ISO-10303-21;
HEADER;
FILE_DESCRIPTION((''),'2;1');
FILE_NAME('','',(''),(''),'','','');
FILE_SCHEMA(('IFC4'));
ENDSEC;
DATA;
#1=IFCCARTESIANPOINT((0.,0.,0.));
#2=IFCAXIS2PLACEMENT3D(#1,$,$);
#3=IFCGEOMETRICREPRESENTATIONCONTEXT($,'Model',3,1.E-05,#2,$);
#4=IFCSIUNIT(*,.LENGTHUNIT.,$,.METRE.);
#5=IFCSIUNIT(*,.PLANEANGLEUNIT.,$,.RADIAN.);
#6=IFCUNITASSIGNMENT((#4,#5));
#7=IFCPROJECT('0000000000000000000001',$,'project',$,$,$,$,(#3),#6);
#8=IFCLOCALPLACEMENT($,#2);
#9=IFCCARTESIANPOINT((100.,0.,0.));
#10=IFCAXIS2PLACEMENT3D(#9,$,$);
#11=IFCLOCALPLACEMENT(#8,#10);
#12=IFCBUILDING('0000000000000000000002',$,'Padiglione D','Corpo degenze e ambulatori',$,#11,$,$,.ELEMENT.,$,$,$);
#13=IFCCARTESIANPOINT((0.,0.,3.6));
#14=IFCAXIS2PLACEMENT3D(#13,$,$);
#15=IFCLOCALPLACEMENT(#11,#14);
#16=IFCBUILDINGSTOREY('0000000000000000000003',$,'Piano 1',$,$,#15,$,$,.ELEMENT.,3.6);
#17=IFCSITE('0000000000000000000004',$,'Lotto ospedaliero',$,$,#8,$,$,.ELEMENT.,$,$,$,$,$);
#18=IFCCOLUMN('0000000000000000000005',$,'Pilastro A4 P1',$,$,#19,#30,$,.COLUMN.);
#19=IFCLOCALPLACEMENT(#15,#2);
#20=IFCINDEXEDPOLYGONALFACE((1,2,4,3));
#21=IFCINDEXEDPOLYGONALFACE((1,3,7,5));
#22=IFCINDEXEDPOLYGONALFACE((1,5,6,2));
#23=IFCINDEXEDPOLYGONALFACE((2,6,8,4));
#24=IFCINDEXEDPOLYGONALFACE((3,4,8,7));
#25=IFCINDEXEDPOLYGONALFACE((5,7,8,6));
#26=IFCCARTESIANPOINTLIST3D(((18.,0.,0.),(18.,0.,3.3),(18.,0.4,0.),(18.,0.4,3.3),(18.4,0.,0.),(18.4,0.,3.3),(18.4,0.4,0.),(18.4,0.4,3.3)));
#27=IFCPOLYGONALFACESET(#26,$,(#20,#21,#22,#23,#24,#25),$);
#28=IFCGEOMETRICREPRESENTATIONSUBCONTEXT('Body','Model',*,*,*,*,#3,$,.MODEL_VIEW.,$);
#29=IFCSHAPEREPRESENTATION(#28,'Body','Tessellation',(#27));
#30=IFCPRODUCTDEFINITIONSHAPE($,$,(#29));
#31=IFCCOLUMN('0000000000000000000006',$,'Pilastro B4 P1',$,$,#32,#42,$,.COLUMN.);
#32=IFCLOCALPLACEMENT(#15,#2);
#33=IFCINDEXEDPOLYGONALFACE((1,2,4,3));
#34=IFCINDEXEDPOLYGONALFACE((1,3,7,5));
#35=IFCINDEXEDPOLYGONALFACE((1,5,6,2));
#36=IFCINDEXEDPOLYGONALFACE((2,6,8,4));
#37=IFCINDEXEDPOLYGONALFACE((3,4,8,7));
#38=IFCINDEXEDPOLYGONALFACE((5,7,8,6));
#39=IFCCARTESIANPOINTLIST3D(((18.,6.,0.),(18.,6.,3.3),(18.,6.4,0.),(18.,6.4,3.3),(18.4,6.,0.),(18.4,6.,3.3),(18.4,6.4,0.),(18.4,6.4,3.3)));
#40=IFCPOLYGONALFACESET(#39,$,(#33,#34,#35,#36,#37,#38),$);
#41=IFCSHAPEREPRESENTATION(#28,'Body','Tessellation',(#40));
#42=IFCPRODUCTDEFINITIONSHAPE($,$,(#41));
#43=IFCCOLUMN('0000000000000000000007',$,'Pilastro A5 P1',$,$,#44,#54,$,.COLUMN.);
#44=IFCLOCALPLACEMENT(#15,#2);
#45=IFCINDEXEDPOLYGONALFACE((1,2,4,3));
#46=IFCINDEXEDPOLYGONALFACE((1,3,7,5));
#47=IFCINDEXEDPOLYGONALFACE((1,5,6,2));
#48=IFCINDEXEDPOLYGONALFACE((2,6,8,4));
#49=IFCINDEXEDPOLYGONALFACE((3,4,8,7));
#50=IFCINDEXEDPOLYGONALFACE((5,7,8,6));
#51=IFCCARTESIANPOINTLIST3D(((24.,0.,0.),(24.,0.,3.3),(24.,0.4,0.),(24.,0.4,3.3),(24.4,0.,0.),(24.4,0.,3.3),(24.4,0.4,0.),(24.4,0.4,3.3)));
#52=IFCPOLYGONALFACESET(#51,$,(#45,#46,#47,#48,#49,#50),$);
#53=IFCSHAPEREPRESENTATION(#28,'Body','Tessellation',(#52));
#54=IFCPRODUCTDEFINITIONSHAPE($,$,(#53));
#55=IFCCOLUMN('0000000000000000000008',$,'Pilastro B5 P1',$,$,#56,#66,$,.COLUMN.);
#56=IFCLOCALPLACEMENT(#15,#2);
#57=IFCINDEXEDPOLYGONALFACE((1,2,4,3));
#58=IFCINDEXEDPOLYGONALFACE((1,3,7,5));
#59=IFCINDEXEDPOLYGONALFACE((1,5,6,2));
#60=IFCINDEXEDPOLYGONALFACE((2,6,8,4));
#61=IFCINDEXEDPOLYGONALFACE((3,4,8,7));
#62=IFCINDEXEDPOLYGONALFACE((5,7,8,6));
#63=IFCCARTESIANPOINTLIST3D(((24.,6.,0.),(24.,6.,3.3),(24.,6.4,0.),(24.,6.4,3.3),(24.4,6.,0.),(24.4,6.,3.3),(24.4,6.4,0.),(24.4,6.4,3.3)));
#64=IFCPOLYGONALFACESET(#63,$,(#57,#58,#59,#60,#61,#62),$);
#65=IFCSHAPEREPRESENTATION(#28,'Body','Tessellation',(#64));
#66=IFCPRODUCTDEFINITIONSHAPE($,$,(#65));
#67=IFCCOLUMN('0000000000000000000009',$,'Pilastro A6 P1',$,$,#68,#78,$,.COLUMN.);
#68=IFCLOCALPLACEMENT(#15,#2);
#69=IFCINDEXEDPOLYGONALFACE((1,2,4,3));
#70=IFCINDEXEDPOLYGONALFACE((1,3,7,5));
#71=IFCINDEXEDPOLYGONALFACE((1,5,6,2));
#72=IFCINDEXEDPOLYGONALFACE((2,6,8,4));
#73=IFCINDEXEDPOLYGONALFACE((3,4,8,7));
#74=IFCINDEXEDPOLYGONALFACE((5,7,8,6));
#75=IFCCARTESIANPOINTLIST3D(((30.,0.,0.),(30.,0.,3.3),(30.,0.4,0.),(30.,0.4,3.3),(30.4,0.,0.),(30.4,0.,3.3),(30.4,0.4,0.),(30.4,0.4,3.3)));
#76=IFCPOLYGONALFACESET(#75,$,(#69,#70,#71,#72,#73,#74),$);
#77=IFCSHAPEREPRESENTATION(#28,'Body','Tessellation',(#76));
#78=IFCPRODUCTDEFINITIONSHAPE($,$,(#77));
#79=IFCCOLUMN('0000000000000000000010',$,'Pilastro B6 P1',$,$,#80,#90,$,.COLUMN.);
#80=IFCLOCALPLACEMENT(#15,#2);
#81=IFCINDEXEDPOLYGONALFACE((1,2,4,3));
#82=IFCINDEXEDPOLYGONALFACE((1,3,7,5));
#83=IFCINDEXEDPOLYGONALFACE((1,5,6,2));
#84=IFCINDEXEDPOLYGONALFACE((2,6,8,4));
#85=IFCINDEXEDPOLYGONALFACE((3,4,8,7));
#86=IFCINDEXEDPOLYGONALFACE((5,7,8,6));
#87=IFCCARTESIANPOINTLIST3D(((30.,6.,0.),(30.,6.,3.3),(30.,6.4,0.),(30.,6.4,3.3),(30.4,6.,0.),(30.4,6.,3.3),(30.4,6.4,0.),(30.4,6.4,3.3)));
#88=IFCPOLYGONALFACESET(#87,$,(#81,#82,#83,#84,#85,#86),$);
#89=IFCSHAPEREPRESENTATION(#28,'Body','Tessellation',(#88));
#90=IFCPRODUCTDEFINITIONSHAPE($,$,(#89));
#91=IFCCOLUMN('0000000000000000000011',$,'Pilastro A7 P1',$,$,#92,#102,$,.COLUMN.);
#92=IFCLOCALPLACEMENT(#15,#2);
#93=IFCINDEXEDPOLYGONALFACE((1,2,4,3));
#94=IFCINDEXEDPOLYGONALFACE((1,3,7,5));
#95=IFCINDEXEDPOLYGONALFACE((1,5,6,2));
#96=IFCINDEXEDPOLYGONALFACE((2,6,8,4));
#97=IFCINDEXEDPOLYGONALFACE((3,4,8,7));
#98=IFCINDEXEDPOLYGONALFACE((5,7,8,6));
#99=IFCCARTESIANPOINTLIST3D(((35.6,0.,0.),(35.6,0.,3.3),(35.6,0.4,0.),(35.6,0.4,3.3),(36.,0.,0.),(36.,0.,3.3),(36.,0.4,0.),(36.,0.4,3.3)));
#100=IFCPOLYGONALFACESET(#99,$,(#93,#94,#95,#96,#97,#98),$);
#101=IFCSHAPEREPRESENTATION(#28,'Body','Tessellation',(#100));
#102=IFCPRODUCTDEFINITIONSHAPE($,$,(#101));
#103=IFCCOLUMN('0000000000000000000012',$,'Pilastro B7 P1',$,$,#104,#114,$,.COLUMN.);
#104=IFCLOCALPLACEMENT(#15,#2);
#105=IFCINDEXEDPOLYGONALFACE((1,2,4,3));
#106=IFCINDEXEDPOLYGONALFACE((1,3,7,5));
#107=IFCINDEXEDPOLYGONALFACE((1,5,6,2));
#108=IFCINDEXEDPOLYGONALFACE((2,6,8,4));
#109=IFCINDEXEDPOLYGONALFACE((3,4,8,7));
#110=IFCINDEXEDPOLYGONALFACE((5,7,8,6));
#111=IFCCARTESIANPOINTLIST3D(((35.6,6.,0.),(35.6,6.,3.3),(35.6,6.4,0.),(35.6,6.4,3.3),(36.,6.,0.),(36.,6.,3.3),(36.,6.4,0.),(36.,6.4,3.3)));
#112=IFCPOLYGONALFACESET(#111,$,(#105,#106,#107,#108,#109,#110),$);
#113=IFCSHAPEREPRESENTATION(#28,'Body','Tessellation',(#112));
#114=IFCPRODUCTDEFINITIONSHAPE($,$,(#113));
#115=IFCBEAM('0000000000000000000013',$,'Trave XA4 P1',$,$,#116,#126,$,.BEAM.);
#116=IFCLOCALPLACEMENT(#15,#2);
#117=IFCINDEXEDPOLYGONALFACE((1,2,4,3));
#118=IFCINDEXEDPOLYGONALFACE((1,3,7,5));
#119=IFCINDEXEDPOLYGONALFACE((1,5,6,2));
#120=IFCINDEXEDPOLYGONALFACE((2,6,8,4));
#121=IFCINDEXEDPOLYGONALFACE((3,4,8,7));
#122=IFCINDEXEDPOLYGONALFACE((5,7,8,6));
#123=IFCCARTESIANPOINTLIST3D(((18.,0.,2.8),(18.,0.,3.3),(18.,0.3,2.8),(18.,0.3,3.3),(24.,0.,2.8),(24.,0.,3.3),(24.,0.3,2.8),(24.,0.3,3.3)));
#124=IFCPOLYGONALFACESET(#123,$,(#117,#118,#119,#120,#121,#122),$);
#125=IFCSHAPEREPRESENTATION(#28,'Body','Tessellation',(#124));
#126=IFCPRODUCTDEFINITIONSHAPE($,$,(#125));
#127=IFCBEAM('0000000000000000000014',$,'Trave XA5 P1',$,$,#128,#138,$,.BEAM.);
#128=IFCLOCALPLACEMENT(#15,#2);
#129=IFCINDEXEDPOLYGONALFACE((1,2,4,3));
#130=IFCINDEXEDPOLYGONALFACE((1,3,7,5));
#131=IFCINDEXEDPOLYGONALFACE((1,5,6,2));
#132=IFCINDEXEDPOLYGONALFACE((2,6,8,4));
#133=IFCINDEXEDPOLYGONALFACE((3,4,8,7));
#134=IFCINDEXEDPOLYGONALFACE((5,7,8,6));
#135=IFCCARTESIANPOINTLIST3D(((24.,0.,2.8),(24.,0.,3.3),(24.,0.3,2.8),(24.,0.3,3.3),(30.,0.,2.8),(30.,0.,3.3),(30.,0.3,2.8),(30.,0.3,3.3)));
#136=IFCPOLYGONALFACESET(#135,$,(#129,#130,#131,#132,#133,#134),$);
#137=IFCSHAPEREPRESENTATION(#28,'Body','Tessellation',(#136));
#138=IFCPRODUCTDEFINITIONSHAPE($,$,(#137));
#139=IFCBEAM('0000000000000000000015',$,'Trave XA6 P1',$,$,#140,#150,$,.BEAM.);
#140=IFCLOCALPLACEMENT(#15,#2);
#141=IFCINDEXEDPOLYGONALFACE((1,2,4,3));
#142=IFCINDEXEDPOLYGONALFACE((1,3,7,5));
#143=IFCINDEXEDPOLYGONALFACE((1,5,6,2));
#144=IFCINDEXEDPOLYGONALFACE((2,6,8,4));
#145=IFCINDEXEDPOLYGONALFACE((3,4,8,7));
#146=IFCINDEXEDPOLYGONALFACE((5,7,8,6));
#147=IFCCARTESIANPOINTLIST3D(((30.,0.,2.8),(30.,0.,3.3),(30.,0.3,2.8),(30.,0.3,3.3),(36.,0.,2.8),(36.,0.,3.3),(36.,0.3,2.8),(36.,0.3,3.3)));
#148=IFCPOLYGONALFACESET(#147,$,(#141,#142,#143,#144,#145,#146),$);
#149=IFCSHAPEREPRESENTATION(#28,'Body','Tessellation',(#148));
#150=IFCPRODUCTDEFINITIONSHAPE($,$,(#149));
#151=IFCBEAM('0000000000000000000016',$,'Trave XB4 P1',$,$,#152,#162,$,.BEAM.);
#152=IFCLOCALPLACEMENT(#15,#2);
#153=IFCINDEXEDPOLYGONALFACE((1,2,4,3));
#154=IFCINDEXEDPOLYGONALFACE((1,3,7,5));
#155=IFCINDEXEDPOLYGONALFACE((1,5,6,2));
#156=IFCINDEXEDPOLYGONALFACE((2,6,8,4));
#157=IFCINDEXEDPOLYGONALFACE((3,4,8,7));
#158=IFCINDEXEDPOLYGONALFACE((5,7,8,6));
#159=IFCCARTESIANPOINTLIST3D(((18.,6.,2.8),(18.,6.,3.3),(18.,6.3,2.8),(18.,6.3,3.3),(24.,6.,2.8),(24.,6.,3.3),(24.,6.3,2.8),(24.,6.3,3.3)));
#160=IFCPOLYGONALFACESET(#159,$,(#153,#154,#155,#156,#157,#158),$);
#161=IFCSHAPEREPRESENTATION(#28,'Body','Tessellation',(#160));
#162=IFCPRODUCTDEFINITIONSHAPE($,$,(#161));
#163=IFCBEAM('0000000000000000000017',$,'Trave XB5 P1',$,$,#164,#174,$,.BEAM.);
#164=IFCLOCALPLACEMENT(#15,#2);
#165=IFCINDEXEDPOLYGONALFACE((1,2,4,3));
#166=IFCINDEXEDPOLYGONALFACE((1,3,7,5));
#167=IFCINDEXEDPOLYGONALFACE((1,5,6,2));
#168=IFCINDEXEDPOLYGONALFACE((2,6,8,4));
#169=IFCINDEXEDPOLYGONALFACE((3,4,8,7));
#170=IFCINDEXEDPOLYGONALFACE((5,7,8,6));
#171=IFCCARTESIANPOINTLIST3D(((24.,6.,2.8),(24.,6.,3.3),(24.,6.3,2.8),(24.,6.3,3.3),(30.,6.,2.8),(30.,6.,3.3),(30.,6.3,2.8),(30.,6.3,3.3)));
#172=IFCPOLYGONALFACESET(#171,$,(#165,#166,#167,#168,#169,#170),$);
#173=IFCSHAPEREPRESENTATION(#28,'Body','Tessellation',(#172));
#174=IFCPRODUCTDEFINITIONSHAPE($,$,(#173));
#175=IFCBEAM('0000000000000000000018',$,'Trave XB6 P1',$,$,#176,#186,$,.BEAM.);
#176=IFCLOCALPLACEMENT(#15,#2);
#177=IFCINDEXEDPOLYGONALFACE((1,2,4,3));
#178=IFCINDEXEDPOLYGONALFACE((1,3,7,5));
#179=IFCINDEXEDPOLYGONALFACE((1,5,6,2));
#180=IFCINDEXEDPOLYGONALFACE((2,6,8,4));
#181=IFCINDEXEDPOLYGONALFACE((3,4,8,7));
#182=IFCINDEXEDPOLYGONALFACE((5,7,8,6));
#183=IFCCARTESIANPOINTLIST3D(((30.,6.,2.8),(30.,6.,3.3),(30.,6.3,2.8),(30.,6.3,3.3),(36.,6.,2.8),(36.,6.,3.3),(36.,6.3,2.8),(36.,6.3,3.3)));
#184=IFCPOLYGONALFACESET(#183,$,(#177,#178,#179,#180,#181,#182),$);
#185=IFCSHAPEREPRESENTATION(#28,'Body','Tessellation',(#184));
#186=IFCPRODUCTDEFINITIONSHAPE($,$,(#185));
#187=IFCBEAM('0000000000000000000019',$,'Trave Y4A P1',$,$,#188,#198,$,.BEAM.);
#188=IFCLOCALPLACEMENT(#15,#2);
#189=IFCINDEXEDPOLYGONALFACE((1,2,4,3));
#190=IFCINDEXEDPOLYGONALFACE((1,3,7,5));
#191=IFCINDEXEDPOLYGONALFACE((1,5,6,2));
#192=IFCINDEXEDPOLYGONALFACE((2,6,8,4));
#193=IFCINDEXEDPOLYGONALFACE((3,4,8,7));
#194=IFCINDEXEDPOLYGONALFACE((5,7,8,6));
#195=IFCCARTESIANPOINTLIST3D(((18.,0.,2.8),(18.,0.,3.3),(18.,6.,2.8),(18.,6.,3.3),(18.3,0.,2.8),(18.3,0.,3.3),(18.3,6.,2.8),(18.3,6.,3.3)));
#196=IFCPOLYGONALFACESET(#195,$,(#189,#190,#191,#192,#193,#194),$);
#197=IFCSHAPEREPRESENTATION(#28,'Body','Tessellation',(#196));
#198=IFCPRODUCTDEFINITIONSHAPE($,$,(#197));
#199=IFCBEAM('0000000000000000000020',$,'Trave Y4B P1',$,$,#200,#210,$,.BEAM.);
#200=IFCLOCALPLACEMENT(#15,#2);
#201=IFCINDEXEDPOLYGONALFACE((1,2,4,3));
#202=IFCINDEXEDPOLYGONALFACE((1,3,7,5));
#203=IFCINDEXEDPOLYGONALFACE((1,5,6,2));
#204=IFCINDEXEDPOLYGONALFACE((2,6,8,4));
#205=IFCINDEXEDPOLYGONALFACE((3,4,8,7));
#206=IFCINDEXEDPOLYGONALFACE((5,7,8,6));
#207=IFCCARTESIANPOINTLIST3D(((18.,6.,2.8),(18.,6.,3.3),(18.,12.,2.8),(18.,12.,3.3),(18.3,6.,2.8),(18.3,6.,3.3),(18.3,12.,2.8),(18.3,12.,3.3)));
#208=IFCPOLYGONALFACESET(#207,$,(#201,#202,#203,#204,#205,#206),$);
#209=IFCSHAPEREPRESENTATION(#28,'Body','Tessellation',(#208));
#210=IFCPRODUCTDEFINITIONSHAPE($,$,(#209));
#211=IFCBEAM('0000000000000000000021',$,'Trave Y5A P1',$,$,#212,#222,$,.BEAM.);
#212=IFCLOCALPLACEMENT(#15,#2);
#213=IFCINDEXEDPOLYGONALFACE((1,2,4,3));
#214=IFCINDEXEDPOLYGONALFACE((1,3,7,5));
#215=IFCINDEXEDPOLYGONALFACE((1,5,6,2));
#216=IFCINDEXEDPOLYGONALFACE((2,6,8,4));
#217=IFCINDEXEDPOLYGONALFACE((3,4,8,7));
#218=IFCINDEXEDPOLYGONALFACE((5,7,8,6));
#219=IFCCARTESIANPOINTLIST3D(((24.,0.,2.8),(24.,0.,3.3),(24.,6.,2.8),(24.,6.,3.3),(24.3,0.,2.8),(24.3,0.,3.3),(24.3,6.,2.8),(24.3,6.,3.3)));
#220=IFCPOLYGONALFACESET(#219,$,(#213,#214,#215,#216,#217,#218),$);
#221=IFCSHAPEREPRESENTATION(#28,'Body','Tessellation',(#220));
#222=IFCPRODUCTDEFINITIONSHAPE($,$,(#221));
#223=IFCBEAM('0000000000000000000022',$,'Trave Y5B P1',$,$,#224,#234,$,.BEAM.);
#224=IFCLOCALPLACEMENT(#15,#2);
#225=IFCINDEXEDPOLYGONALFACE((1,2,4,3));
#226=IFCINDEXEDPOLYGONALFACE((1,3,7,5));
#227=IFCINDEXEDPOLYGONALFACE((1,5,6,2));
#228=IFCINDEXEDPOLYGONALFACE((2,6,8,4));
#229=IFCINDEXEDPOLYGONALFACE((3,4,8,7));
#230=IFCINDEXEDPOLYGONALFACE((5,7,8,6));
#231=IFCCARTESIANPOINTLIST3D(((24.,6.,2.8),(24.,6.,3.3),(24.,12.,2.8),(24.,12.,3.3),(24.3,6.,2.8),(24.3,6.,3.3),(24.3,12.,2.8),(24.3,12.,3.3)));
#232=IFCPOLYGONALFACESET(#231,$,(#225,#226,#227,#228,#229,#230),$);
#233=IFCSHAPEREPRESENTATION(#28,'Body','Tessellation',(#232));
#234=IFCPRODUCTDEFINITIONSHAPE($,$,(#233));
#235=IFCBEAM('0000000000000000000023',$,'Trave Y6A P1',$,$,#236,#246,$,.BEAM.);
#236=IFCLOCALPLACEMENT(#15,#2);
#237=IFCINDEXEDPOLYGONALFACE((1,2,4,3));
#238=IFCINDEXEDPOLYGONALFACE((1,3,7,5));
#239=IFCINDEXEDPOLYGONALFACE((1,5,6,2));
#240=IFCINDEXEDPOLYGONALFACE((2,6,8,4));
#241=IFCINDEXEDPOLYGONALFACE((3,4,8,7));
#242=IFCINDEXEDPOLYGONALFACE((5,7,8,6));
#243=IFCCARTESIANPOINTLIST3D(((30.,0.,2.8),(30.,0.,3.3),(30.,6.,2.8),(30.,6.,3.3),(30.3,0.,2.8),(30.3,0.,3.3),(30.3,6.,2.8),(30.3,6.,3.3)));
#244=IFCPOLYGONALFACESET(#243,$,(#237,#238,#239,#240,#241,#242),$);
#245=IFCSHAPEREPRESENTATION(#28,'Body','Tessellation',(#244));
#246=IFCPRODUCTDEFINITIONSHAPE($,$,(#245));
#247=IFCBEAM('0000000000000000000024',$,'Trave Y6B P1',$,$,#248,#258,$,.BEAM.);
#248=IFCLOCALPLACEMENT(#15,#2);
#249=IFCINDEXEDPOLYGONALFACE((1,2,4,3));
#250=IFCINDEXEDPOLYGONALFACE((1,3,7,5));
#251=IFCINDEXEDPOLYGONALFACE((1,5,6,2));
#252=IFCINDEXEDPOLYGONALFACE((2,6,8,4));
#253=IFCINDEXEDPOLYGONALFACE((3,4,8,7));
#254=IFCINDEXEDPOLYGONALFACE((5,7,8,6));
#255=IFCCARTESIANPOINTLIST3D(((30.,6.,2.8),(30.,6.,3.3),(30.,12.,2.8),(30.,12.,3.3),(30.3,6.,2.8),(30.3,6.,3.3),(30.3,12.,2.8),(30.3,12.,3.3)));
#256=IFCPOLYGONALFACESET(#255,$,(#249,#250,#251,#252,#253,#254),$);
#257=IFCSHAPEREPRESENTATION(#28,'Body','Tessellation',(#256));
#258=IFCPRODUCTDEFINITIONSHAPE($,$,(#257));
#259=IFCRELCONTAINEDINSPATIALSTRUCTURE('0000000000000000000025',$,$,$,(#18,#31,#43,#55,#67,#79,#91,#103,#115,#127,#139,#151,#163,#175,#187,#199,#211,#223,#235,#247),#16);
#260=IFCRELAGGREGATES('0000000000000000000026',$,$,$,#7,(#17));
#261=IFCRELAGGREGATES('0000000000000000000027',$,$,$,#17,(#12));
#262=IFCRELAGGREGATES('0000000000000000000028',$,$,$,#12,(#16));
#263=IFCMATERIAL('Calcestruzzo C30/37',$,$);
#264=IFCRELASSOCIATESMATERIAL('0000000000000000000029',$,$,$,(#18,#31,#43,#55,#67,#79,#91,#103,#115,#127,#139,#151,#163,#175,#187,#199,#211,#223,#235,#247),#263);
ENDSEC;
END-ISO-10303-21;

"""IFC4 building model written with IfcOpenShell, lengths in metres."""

from ifc_helpers import new_model, si_unit, frame, frame_2d, origin, place, context, subcontext, project, spatial, rectangle, extrude, material, element, save


model = new_model("IFC4")

# Units and contexts
model_context = context("Model", 3, precision=1e-05, world=origin())
body_context = subcontext(model_context, "Body", "Model", "MODEL_VIEW")
ifc_project = project(units=[si_unit("LENGTHUNIT", "METRE"), si_unit("PLANEANGLEUNIT", "RADIAN")], contexts=[model_context])

# Site, building, storey
site_placement = place(None, origin())
site = spatial("IfcSite", under=ifc_project, at=site_placement, Name="Lotto ospedaliero", CompositionType="ELEMENT")
building_placement = place(site_placement, frame((100.0, 0.0, 0.0)))
building = spatial("IfcBuilding", under=site, at=building_placement, Name="Padiglione D", Description="Corpo degenze e ambulatori", CompositionType="ELEMENT")
storey_placement = place(building_placement, frame((0.0, 0.0, 3.6)))
storey = spatial("IfcBuildingStorey", under=building, at=storey_placement, Name="Piano 1", CompositionType="ELEMENT", Elevation=3.6)

# Columns
ifc_material_1 = material(Name="Calcestruzzo C30/37")
for number, where, name in (
    (1, (18.0, 0.0, 0.0), "Pilastro A4 P1"),
    (2, (18.0, 6.0, 0.0), "Pilastro B4 P1"),
    (3, (24.0, 0.0, 0.0), "Pilastro A5 P1"),
    (4, (24.0, 6.0, 0.0), "Pilastro B5 P1"),
    (5, (30.0, 0.0, 0.0), "Pilastro A6 P1"),
    (6, (30.0, 6.0, 0.0), "Pilastro B6 P1"),
    (7, (35.6, 0.0, 0.0), "Pilastro A7 P1"),
    (8, (35.6, 6.0, 0.0), "Pilastro B7 P1"),
):
    element("IfcColumn", number, at=place(storey_placement, frame(where)), inside=storey, material=ifc_material_1, Name=name, PredefinedType="COLUMN", context=body_context, shape_type="SweptSolid", body=[
        extrude(rectangle(XDim=0.4, YDim=0.4, at=frame_2d((0.2, 0.2))), origin(), (0.0, 0.0, 1.0), 3.3),
    ])

# Beams
for number, where, name in (
    (9, (18.0, 0.0, 2.8), "Trave XA4 P1"),
    (10, (24.0, 0.0, 2.8), "Trave XA5 P1"),
    (11, (30.0, 0.0, 2.8), "Trave XA6 P1"),
    (12, (18.0, 6.0, 2.8), "Trave XB4 P1"),
    (13, (24.0, 6.0, 2.8), "Trave XB5 P1"),
    (14, (30.0, 6.0, 2.8), "Trave XB6 P1"),
):
    element("IfcBeam", number, at=place(storey_placement, frame(where)), inside=storey, material=ifc_material_1, Name=name, PredefinedType="BEAM", context=body_context, shape_type="SweptSolid", body=[
        extrude(rectangle(XDim=6.0, YDim=0.3, at=frame_2d((3.0, 0.15))), origin(), (0.0, 0.0, 1.0), 0.5),
    ])
for number, where, name in (
    (15, (18.0, 0.0, 2.8), "Trave Y4A P1"),
    (16, (18.0, 6.0, 2.8), "Trave Y4B P1"),
    (17, (24.0, 0.0, 2.8), "Trave Y5A P1"),
    (18, (24.0, 6.0, 2.8), "Trave Y5B P1"),
    (19, (30.0, 0.0, 2.8), "Trave Y6A P1"),
    (20, (30.0, 6.0, 2.8), "Trave Y6B P1"),
):
    element("IfcBeam", number, at=place(storey_placement, frame(where)), inside=storey, material=ifc_material_1, Name=name, PredefinedType="BEAM", context=body_context, shape_type="SweptSolid", body=[
        extrude(rectangle(XDim=0.3, YDim=6.0, at=frame_2d((0.15, 3.0))), origin(), (0.0, 0.0, 1.0), 0.5),
    ])

save(model, "model.ifc")
